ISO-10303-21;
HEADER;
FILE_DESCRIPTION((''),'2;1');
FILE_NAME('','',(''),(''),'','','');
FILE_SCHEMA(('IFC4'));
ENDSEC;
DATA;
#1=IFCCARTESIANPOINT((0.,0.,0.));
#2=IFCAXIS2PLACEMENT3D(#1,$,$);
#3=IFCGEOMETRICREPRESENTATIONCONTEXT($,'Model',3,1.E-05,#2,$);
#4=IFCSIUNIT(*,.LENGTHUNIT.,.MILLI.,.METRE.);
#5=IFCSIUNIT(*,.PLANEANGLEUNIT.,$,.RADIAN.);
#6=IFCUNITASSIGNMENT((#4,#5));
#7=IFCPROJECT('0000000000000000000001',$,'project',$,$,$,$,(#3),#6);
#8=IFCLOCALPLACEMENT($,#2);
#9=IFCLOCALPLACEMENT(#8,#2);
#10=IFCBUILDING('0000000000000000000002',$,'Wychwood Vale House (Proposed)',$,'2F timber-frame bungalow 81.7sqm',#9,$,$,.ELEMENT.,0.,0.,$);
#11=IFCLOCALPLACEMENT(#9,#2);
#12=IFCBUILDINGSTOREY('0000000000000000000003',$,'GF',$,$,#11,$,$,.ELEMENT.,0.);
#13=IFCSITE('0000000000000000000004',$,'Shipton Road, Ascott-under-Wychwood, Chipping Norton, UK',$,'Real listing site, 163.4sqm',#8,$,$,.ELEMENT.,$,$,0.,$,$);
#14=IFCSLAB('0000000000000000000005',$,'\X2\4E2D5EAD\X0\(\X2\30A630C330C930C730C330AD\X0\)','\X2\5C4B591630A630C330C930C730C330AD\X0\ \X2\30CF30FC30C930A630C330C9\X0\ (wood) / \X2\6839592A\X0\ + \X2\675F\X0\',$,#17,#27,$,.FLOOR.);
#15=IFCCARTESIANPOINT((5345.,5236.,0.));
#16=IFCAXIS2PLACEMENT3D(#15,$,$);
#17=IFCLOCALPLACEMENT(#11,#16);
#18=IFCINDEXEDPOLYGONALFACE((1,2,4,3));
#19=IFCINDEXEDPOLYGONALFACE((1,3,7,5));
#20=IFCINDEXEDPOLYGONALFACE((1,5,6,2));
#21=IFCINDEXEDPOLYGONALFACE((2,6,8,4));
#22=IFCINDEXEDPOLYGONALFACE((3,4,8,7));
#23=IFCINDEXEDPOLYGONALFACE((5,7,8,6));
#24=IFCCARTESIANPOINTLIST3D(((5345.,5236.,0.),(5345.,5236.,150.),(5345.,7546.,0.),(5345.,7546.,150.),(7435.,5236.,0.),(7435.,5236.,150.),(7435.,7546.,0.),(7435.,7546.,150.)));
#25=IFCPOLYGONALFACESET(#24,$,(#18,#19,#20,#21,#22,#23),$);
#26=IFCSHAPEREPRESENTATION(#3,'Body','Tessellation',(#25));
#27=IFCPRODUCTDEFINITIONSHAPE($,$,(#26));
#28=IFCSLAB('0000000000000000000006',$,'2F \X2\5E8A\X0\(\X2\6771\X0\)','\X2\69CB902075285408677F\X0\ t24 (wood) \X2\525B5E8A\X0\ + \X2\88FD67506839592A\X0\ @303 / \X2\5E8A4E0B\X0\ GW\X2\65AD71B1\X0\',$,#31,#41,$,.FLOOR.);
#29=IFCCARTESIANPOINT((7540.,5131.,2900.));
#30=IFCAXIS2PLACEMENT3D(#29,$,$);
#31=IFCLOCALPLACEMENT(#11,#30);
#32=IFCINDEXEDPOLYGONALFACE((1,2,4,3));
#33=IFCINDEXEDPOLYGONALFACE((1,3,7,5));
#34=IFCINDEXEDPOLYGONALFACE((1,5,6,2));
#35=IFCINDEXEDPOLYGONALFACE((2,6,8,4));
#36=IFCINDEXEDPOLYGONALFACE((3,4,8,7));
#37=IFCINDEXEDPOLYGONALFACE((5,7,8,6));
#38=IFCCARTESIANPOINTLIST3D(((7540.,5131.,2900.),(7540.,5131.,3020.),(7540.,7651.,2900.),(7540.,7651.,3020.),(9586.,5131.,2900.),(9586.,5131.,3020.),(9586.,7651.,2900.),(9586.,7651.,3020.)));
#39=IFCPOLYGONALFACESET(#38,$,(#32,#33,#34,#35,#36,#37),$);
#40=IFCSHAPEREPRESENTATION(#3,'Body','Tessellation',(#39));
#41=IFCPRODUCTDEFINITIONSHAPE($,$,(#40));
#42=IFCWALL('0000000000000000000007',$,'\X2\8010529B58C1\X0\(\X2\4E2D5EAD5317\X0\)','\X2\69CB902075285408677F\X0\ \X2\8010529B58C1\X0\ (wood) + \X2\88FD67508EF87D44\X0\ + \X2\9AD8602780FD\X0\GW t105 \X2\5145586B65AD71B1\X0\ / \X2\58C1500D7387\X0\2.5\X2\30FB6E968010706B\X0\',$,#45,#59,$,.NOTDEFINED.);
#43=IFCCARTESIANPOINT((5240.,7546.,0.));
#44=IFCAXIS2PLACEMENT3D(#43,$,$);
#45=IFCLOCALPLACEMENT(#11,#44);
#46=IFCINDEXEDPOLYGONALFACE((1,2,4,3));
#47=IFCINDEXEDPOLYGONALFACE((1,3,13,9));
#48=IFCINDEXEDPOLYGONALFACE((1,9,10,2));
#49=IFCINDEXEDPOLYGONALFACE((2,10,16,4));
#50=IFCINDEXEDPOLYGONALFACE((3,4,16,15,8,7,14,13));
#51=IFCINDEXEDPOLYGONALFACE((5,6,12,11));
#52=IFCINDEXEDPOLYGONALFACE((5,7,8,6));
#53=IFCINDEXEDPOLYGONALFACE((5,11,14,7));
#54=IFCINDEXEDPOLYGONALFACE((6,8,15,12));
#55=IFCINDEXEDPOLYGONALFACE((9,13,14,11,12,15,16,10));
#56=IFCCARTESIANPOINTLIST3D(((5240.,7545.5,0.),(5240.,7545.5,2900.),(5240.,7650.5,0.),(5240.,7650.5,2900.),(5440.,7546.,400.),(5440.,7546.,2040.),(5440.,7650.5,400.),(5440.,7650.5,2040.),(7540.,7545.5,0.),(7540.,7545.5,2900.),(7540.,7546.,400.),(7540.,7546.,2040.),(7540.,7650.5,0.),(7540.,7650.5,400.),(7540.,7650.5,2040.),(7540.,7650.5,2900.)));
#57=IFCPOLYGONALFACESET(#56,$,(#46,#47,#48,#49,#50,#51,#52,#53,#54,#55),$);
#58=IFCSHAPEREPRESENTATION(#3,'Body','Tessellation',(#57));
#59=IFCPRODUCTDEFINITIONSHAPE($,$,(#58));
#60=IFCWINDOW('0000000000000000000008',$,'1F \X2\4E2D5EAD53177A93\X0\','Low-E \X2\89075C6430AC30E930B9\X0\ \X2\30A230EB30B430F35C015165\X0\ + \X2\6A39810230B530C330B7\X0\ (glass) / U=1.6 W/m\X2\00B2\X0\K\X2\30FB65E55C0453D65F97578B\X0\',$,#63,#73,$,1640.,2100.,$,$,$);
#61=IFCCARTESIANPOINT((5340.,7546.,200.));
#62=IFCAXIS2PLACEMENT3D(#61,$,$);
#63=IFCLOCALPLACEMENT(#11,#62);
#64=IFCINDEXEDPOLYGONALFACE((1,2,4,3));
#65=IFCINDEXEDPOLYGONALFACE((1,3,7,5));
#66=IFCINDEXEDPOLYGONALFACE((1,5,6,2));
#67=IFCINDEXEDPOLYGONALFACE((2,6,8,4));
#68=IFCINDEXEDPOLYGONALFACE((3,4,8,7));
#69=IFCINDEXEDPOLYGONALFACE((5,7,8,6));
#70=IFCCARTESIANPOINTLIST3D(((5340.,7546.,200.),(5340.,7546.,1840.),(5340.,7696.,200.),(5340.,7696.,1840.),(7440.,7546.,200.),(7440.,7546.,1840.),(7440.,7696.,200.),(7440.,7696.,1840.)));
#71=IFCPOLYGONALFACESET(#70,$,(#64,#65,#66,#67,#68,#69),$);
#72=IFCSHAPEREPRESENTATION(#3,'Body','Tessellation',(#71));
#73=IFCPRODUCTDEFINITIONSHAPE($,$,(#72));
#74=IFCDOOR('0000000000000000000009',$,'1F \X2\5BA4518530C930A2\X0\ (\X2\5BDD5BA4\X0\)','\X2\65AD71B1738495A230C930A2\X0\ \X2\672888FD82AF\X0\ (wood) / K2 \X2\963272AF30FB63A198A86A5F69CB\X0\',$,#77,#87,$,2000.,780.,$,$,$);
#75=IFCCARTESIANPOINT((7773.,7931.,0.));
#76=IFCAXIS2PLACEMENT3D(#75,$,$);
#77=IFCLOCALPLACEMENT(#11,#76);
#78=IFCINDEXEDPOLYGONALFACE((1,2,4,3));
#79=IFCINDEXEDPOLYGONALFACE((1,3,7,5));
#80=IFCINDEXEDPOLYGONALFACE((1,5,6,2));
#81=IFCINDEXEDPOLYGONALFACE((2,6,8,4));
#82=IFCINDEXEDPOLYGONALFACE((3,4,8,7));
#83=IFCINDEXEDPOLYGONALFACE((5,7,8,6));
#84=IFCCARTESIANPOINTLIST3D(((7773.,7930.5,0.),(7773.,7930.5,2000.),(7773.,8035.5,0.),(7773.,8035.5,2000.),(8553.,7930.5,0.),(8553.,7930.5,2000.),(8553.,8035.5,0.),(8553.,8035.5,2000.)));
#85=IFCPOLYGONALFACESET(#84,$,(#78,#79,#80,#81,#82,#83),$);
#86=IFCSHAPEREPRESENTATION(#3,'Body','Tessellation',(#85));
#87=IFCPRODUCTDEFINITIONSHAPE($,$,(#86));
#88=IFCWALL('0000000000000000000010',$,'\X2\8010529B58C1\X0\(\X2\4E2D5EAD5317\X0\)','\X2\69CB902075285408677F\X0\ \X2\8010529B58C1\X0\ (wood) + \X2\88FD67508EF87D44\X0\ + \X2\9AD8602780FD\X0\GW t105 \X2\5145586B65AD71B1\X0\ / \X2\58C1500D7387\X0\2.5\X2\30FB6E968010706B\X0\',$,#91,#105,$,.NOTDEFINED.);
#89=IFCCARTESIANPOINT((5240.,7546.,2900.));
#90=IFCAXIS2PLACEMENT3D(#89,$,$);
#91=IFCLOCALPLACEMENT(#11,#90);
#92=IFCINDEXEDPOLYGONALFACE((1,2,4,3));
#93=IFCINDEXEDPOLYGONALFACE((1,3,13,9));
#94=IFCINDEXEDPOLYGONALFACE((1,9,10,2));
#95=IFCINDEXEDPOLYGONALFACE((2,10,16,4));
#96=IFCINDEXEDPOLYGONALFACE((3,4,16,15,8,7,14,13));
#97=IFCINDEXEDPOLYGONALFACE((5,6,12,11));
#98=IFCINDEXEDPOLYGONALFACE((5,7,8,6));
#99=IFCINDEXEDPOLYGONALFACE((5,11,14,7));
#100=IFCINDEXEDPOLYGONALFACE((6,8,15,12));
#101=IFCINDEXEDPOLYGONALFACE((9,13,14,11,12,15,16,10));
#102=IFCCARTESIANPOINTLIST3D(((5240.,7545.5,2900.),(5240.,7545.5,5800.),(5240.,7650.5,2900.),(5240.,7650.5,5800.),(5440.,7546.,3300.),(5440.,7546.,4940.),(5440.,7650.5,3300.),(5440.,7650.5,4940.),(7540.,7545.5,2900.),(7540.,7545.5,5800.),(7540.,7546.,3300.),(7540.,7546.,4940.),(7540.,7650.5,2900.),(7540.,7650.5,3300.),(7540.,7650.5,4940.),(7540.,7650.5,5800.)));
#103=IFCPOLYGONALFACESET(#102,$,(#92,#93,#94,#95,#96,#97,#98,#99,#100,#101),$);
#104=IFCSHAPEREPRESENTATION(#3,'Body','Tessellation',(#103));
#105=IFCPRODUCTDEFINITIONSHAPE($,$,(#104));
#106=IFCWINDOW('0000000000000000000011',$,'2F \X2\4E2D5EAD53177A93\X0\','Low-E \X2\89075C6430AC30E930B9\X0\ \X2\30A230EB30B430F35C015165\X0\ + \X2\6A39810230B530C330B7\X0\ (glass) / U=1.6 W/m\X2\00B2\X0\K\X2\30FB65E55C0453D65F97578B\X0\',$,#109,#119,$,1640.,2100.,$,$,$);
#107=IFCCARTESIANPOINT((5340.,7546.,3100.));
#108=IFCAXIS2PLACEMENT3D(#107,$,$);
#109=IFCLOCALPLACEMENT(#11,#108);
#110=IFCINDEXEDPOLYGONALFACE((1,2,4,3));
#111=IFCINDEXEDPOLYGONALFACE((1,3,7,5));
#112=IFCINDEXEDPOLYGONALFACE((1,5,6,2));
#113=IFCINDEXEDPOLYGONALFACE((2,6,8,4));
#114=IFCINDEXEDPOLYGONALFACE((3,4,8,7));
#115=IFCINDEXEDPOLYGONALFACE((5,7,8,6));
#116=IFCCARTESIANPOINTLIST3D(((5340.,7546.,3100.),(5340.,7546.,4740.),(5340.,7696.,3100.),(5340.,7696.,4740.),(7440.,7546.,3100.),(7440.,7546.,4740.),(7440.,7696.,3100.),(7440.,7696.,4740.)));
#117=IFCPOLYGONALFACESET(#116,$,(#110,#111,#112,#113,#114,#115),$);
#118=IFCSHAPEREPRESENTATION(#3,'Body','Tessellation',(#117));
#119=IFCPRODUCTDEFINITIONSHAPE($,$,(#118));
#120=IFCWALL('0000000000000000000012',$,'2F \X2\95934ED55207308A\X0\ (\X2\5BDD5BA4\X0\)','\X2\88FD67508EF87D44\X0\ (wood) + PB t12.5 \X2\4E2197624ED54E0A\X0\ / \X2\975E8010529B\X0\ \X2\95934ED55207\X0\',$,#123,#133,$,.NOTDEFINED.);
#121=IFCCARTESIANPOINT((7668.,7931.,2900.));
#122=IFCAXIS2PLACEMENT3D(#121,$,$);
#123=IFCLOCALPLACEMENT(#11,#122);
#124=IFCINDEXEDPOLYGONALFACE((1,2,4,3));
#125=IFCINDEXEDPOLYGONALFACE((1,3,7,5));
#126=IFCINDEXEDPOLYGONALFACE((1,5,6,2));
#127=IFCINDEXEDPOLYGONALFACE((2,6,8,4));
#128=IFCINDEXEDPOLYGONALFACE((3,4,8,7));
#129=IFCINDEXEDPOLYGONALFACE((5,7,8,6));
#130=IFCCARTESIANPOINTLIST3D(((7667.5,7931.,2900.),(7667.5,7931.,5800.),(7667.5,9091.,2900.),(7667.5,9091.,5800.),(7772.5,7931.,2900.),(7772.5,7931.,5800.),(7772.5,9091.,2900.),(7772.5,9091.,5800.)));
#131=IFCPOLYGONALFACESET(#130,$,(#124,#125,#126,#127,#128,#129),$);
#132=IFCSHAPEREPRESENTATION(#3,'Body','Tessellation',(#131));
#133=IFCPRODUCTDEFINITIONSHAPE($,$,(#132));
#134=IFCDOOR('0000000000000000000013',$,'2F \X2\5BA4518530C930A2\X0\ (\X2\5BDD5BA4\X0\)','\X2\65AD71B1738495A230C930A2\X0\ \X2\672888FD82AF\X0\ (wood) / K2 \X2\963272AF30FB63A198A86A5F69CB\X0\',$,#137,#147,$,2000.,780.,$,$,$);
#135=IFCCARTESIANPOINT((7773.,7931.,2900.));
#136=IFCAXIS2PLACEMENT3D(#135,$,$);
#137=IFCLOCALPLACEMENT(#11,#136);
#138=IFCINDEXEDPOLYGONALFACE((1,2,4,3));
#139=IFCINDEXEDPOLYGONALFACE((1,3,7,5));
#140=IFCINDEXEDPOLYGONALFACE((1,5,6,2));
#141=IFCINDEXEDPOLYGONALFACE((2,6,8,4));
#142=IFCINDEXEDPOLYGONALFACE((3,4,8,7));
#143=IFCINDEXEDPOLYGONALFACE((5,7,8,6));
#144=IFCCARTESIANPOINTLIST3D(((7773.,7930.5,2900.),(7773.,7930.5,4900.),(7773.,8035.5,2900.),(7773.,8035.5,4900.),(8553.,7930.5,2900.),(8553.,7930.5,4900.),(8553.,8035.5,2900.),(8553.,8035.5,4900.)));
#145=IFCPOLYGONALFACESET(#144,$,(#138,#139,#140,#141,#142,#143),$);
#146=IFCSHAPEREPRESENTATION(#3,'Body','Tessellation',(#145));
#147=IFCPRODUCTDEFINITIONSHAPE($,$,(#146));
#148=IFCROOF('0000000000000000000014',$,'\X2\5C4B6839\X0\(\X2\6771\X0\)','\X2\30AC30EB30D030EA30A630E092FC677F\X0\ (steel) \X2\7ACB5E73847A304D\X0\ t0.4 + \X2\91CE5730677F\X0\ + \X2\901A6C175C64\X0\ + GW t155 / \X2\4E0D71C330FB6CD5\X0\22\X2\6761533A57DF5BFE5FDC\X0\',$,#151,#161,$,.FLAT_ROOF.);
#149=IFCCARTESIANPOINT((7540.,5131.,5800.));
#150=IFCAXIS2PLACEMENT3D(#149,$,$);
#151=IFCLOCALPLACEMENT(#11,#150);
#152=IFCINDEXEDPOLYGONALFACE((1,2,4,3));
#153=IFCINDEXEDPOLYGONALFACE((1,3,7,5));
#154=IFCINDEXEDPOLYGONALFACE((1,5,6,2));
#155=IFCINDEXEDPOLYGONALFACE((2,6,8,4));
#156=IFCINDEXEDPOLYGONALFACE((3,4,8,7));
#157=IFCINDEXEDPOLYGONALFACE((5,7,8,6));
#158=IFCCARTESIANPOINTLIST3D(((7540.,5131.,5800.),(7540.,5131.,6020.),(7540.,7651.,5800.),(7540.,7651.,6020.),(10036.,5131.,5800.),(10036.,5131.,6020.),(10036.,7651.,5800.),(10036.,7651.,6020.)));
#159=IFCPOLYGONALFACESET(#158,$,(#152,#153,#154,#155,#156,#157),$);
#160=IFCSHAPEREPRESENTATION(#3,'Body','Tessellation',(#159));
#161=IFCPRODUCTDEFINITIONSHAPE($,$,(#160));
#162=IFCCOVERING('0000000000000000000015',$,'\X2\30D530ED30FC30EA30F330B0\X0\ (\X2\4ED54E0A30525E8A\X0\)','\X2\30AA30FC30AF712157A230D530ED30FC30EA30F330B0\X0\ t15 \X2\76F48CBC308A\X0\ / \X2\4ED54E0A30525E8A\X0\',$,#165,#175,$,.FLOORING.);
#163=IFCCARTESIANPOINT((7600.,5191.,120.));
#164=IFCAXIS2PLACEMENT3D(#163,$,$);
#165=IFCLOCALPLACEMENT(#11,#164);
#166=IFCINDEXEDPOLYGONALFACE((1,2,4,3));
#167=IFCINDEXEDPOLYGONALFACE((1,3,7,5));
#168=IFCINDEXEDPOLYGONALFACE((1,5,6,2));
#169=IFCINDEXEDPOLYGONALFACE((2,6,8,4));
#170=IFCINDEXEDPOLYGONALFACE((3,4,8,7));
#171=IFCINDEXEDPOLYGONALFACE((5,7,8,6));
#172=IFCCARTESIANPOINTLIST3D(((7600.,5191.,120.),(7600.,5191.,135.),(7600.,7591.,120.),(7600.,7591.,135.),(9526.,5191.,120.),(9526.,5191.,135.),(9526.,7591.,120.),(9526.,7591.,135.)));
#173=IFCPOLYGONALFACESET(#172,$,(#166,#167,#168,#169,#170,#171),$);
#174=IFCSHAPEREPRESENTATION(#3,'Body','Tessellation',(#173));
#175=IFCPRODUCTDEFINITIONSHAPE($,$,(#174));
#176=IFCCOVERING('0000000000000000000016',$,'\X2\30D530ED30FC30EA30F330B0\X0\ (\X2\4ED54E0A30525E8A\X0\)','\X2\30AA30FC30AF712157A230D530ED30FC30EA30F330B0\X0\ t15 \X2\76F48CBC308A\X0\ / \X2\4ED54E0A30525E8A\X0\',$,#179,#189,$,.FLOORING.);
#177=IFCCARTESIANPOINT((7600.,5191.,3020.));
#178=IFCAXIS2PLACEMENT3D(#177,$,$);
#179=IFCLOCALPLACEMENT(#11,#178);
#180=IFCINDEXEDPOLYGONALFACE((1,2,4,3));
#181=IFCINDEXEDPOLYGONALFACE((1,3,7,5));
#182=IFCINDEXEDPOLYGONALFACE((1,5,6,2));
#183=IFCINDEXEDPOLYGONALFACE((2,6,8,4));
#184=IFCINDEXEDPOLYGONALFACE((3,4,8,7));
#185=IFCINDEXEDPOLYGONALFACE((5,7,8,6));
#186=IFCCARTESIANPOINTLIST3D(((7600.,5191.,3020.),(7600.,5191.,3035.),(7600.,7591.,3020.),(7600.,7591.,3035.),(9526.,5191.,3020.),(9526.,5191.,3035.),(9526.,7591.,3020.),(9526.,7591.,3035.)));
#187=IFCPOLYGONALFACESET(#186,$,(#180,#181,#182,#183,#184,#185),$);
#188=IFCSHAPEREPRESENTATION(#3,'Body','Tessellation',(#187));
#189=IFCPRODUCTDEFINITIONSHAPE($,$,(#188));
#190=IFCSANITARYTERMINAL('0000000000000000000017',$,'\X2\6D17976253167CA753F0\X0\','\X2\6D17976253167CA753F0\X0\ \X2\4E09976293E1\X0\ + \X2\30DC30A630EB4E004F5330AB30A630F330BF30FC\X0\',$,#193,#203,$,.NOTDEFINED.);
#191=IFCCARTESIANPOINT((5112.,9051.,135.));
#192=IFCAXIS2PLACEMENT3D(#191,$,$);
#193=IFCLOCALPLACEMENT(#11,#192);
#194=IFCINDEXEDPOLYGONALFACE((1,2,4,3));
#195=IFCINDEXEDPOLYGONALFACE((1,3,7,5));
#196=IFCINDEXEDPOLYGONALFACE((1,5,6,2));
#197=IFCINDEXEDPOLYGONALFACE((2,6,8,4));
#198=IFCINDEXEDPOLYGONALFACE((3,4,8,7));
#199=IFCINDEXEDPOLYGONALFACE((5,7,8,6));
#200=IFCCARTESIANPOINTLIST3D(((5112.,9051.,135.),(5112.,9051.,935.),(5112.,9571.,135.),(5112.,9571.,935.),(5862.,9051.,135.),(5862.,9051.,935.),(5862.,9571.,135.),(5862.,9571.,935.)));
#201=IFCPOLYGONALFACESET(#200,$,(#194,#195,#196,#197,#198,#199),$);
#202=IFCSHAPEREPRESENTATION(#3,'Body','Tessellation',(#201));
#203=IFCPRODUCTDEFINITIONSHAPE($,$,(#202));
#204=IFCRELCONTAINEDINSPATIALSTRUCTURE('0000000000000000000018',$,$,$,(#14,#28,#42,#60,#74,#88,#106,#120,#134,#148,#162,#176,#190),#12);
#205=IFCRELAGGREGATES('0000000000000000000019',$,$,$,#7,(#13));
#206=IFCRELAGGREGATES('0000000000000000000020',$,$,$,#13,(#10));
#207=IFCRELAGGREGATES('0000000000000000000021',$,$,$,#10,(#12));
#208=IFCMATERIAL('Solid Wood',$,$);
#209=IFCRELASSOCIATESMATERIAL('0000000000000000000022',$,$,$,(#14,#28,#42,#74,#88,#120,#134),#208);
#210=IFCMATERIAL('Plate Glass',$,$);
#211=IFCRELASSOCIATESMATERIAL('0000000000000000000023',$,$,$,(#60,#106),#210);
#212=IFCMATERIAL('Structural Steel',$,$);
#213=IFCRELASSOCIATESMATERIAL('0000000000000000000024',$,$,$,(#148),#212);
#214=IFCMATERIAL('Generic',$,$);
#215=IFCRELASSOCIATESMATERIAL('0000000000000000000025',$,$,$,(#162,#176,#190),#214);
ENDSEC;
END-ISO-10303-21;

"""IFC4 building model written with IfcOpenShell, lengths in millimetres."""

from ifc_helpers import new_model, si_unit, frame, frame_2d, origin, place, context, project, spatial, rectangle, extrude, material, element, fill, save


model = new_model("IFC4")

# Units and contexts
model_context = context("Model", 3, precision=1e-05, world=origin())
ifc_project = project(units=[si_unit("LENGTHUNIT", "METRE", prefix="MILLI"), si_unit("PLANEANGLEUNIT", "RADIAN")], contexts=[model_context])

# Site, building, storey
site_placement = place(None, origin())
site = spatial("IfcSite", under=ifc_project, at=site_placement, Name="Shipton Road, Ascott-under-Wychwood, Chipping Norton, UK", ObjectType="Real listing site, 163.4sqm", CompositionType="ELEMENT", RefElevation=0.0)
building_placement = place(site_placement, origin())
building = spatial("IfcBuilding", under=site, at=building_placement, Name="Wychwood Vale House (Proposed)", ObjectType="2F timber-frame bungalow 81.7sqm", CompositionType="ELEMENT", ElevationOfRefHeight=0.0, ElevationOfTerrain=0.0)
storey_placement = place(building_placement, origin())
storey = spatial("IfcBuildingStorey", under=building, at=storey_placement, Name="GF", CompositionType="ELEMENT", Elevation=0.0)

# Slabs
ifc_material_1 = material(Name="Solid Wood")
slab_1_placement = place(storey_placement, frame((5345.0, 5236.0, 0.0)))
element("IfcSlab", 1, at=slab_1_placement, inside=storey, material=ifc_material_1, Name="中庭(ウッドデッキ)", Description="屋外ウッドデッキ ハードウッド (wood) / 根太 + 束", PredefinedType="FLOOR", context=model_context, shape_type="SweptSolid", body=[
    extrude(rectangle(XDim=2090.0, YDim=2310.0, at=frame_2d((1045.0, 1155.0))), frame((5345.0, 5236.0, 0.0)), (0.0, 0.0, 1.0), 150.0),
])
slab_2_placement = place(storey_placement, frame((7540.0, 5131.0, 2900.0)))
element("IfcSlab", 2, at=slab_2_placement, inside=storey, material=ifc_material_1, Name="2F 床(東)", Description="構造用合板 t24 (wood) 剛床 + 製材根太 @303 / 床下 GW断熱", PredefinedType="FLOOR", context=model_context, shape_type="SweptSolid", body=[
    extrude(rectangle(XDim=2046.0, YDim=2520.0, at=frame_2d((1023.0, 1260.0))), frame((7540.0, 5131.0, 2900.0)), (0.0, 0.0, 1.0), 120.0),
])

# Wall, opening, window
wall_1_placement = place(storey_placement, frame((5240.0, 7546.0, 0.0)))
wall_1 = element("IfcWall", 3, at=wall_1_placement, inside=storey, material=ifc_material_1, Name="耐力壁(中庭北)", Description="構造用合板 耐力壁 (wood) + 製材軸組 + 高性能GW t105 充填断熱 / 壁倍率2.5・準耐火", PredefinedType="NOTDEFINED", context=model_context, shape_type="SweptSolid", body=[
    extrude(rectangle(XDim=2300.0, YDim=105.0, at=frame_2d((1150.0, 52.0))), frame((5240.0, 7546.0, 0.0)), (0.0, 0.0, 1.0), 2900.0),
])
opening_1_placement = place(storey_placement, frame((5340.0, 7546.0, 200.0)))
opening_1 = element("IfcOpeningElement", 4, at=opening_1_placement, cuts=wall_1, PredefinedType="NOTDEFINED", context=model_context, shape_type="SweptSolid", body=[
    extrude(rectangle(XDim=2100.0, YDim=150.0, at=frame_2d((1050.0, 75.0))), frame((5340.0, 7546.0, 200.0)), (0.0, 0.0, 1.0), 1640.0),
])
ifc_material_2 = material(Name="Plate Glass")
window_1_placement = place(storey_placement, frame((5340.0, 7546.0, 200.0)))
window_1 = element("IfcWindow", 5, at=window_1_placement, inside=storey, material=ifc_material_2, Name="1F 中庭北窓", Description="Low-E 複層ガラス アルゴン封入 + 樹脂サッシ (glass) / U=1.6 W/m²K・日射取得型", OverallHeight=1640.0, OverallWidth=2100.0, context=model_context, shape_type="SweptSolid", body=[
    extrude(rectangle(XDim=2100.0, YDim=150.0, at=frame_2d((1050.0, 75.0))), frame((5340.0, 7546.0, 200.0)), (0.0, 0.0, 1.0), 1640.0),
])
fill(opening_1, window_1)

# Door
door_1_placement = place(storey_placement, frame((7773.0, 7931.0, 0.0)))
element("IfcDoor", 6, at=door_1_placement, inside=storey, material=ifc_material_1, Name="1F 室内ドア (寝室)", Description="断熱玄関ドア 木製芯 (wood) / K2 防犯・採風機構", OverallHeight=2000.0, OverallWidth=780.0, context=model_context, shape_type="SweptSolid", body=[
    extrude(rectangle(XDim=780.0, YDim=105.0, at=frame_2d((390.0, 52.0))), frame((7773.0, 7931.0, 0.0)), (0.0, 0.0, 1.0), 2000.0),
])

# Wall, opening, window
wall_2_placement = place(storey_placement, frame((5240.0, 7546.0, 2900.0)))
wall_2 = element("IfcWall", 7, at=wall_2_placement, inside=storey, material=ifc_material_1, Name="耐力壁(中庭北)", Description="構造用合板 耐力壁 (wood) + 製材軸組 + 高性能GW t105 充填断熱 / 壁倍率2.5・準耐火", PredefinedType="NOTDEFINED", context=model_context, shape_type="SweptSolid", body=[
    extrude(rectangle(XDim=2300.0, YDim=105.0, at=frame_2d((1150.0, 52.0))), frame((5240.0, 7546.0, 2900.0)), (0.0, 0.0, 1.0), 2900.0),
])
opening_2_placement = place(storey_placement, frame((5340.0, 7546.0, 3100.0)))
opening_2 = element("IfcOpeningElement", 8, at=opening_2_placement, cuts=wall_2, PredefinedType="NOTDEFINED", context=model_context, shape_type="SweptSolid", body=[
    extrude(rectangle(XDim=2100.0, YDim=150.0, at=frame_2d((1050.0, 75.0))), frame((5340.0, 7546.0, 3100.0)), (0.0, 0.0, 1.0), 1640.0),
])
window_2_placement = place(storey_placement, frame((5340.0, 7546.0, 3100.0)))
window_2 = element("IfcWindow", 9, at=window_2_placement, inside=storey, material=ifc_material_2, Name="2F 中庭北窓", Description="Low-E 複層ガラス アルゴン封入 + 樹脂サッシ (glass) / U=1.6 W/m²K・日射取得型", OverallHeight=1640.0, OverallWidth=2100.0, context=model_context, shape_type="SweptSolid", body=[
    extrude(rectangle(XDim=2100.0, YDim=150.0, at=frame_2d((1050.0, 75.0))), frame((5340.0, 7546.0, 3100.0)), (0.0, 0.0, 1.0), 1640.0),
])
fill(opening_2, window_2)

# Wall
wall_3_placement = place(storey_placement, frame((7668.0, 7931.0, 2900.0)))
element("IfcWall", 10, at=wall_3_placement, inside=storey, material=ifc_material_1, Name="2F 間仕切り (寝室)", Description="製材軸組 (wood) + PB t12.5 両面仕上 / 非耐力 間仕切", PredefinedType="NOTDEFINED", context=model_context, shape_type="SweptSolid", body=[
    extrude(rectangle(XDim=105.0, YDim=1160.0, at=frame_2d((52.0, 580.0))), frame((7668.0, 7931.0, 2900.0)), (0.0, 0.0, 1.0), 2900.0),
])

# Door
door_2_placement = place(storey_placement, frame((7773.0, 7931.0, 2900.0)))
element("IfcDoor", 11, at=door_2_placement, inside=storey, material=ifc_material_1, Name="2F 室内ドア (寝室)", Description="断熱玄関ドア 木製芯 (wood) / K2 防犯・採風機構", OverallHeight=2000.0, OverallWidth=780.0, context=model_context, shape_type="SweptSolid", body=[
    extrude(rectangle(XDim=780.0, YDim=105.0, at=frame_2d((390.0, 52.0))), frame((7773.0, 7931.0, 2900.0)), (0.0, 0.0, 1.0), 2000.0),
])

# Roof
ifc_material_3 = material(Name="Structural Steel")
for number, where, name in (
    (12, (7540.0, 5131.0, 5800.0), "屋根(東)"),
):
    element("IfcRoof", number, at=place(storey_placement, frame(where)), inside=storey, material=ifc_material_3, Name=name, Description="ガルバリウム鋼板 (steel) 立平葺き t0.4 + 野地板 + 通気層 + GW t155 / 不燃・法22条区域対応", PredefinedType="FLAT_ROOF", context=model_context, shape_type="SweptSolid", body=[
        extrude(rectangle(XDim=2496.0, YDim=2520.0, at=frame_2d((1248.0, 1260.0))), frame((7540.0, 5131.0, 5800.0)), (0.0, 0.0, 1.0), 220.0),
    ])

# Coverings
ifc_material_4 = material(Name="Generic")
covering_1_placement = place(storey_placement, frame((7600.0, 5191.0, 120.0)))
element("IfcCovering", 13, at=covering_1_placement, inside=storey, material=ifc_material_4, Name="フローリング (仕上げ床)", Description="オーク無垢フローリング t15 直貼り / 仕上げ床", PredefinedType="FLOORING", context=model_context, shape_type="SweptSolid", body=[
    extrude(rectangle(XDim=1926.0, YDim=2400.0, at=frame_2d((963.0, 1200.0))), frame((7600.0, 5191.0, 120.0)), (0.0, 0.0, 1.0), 15.0),
])
covering_2_placement = place(storey_placement, frame((7600.0, 5191.0, 3020.0)))
element("IfcCovering", 14, at=covering_2_placement, inside=storey, material=ifc_material_4, Name="フローリング (仕上げ床)", Description="オーク無垢フローリング t15 直貼り / 仕上げ床", PredefinedType="FLOORING", context=model_context, shape_type="SweptSolid", body=[
    extrude(rectangle(XDim=1926.0, YDim=2400.0, at=frame_2d((963.0, 1200.0))), frame((7600.0, 5191.0, 3020.0)), (0.0, 0.0, 1.0), 15.0),
])

# Sanitary terminal
sanitary_terminal_1_placement = place(storey_placement, frame((5112.0, 9051.0, 135.0)))
element("IfcSanitaryTerminal", 15, at=sanitary_terminal_1_placement, inside=storey, material=ifc_material_4, Name="洗面化粧台", Description="洗面化粧台 三面鏡 + ボウル一体カウンター", PredefinedType="NOTDEFINED", context=model_context, shape_type="SweptSolid", body=[
    extrude(rectangle(XDim=750.0, YDim=520.0, at=frame_2d((375.0, 260.0))), frame((5112.0, 9051.0, 135.0)), (0.0, 0.0, 1.0), 800.0),
])

save(model, "model.ifc")
